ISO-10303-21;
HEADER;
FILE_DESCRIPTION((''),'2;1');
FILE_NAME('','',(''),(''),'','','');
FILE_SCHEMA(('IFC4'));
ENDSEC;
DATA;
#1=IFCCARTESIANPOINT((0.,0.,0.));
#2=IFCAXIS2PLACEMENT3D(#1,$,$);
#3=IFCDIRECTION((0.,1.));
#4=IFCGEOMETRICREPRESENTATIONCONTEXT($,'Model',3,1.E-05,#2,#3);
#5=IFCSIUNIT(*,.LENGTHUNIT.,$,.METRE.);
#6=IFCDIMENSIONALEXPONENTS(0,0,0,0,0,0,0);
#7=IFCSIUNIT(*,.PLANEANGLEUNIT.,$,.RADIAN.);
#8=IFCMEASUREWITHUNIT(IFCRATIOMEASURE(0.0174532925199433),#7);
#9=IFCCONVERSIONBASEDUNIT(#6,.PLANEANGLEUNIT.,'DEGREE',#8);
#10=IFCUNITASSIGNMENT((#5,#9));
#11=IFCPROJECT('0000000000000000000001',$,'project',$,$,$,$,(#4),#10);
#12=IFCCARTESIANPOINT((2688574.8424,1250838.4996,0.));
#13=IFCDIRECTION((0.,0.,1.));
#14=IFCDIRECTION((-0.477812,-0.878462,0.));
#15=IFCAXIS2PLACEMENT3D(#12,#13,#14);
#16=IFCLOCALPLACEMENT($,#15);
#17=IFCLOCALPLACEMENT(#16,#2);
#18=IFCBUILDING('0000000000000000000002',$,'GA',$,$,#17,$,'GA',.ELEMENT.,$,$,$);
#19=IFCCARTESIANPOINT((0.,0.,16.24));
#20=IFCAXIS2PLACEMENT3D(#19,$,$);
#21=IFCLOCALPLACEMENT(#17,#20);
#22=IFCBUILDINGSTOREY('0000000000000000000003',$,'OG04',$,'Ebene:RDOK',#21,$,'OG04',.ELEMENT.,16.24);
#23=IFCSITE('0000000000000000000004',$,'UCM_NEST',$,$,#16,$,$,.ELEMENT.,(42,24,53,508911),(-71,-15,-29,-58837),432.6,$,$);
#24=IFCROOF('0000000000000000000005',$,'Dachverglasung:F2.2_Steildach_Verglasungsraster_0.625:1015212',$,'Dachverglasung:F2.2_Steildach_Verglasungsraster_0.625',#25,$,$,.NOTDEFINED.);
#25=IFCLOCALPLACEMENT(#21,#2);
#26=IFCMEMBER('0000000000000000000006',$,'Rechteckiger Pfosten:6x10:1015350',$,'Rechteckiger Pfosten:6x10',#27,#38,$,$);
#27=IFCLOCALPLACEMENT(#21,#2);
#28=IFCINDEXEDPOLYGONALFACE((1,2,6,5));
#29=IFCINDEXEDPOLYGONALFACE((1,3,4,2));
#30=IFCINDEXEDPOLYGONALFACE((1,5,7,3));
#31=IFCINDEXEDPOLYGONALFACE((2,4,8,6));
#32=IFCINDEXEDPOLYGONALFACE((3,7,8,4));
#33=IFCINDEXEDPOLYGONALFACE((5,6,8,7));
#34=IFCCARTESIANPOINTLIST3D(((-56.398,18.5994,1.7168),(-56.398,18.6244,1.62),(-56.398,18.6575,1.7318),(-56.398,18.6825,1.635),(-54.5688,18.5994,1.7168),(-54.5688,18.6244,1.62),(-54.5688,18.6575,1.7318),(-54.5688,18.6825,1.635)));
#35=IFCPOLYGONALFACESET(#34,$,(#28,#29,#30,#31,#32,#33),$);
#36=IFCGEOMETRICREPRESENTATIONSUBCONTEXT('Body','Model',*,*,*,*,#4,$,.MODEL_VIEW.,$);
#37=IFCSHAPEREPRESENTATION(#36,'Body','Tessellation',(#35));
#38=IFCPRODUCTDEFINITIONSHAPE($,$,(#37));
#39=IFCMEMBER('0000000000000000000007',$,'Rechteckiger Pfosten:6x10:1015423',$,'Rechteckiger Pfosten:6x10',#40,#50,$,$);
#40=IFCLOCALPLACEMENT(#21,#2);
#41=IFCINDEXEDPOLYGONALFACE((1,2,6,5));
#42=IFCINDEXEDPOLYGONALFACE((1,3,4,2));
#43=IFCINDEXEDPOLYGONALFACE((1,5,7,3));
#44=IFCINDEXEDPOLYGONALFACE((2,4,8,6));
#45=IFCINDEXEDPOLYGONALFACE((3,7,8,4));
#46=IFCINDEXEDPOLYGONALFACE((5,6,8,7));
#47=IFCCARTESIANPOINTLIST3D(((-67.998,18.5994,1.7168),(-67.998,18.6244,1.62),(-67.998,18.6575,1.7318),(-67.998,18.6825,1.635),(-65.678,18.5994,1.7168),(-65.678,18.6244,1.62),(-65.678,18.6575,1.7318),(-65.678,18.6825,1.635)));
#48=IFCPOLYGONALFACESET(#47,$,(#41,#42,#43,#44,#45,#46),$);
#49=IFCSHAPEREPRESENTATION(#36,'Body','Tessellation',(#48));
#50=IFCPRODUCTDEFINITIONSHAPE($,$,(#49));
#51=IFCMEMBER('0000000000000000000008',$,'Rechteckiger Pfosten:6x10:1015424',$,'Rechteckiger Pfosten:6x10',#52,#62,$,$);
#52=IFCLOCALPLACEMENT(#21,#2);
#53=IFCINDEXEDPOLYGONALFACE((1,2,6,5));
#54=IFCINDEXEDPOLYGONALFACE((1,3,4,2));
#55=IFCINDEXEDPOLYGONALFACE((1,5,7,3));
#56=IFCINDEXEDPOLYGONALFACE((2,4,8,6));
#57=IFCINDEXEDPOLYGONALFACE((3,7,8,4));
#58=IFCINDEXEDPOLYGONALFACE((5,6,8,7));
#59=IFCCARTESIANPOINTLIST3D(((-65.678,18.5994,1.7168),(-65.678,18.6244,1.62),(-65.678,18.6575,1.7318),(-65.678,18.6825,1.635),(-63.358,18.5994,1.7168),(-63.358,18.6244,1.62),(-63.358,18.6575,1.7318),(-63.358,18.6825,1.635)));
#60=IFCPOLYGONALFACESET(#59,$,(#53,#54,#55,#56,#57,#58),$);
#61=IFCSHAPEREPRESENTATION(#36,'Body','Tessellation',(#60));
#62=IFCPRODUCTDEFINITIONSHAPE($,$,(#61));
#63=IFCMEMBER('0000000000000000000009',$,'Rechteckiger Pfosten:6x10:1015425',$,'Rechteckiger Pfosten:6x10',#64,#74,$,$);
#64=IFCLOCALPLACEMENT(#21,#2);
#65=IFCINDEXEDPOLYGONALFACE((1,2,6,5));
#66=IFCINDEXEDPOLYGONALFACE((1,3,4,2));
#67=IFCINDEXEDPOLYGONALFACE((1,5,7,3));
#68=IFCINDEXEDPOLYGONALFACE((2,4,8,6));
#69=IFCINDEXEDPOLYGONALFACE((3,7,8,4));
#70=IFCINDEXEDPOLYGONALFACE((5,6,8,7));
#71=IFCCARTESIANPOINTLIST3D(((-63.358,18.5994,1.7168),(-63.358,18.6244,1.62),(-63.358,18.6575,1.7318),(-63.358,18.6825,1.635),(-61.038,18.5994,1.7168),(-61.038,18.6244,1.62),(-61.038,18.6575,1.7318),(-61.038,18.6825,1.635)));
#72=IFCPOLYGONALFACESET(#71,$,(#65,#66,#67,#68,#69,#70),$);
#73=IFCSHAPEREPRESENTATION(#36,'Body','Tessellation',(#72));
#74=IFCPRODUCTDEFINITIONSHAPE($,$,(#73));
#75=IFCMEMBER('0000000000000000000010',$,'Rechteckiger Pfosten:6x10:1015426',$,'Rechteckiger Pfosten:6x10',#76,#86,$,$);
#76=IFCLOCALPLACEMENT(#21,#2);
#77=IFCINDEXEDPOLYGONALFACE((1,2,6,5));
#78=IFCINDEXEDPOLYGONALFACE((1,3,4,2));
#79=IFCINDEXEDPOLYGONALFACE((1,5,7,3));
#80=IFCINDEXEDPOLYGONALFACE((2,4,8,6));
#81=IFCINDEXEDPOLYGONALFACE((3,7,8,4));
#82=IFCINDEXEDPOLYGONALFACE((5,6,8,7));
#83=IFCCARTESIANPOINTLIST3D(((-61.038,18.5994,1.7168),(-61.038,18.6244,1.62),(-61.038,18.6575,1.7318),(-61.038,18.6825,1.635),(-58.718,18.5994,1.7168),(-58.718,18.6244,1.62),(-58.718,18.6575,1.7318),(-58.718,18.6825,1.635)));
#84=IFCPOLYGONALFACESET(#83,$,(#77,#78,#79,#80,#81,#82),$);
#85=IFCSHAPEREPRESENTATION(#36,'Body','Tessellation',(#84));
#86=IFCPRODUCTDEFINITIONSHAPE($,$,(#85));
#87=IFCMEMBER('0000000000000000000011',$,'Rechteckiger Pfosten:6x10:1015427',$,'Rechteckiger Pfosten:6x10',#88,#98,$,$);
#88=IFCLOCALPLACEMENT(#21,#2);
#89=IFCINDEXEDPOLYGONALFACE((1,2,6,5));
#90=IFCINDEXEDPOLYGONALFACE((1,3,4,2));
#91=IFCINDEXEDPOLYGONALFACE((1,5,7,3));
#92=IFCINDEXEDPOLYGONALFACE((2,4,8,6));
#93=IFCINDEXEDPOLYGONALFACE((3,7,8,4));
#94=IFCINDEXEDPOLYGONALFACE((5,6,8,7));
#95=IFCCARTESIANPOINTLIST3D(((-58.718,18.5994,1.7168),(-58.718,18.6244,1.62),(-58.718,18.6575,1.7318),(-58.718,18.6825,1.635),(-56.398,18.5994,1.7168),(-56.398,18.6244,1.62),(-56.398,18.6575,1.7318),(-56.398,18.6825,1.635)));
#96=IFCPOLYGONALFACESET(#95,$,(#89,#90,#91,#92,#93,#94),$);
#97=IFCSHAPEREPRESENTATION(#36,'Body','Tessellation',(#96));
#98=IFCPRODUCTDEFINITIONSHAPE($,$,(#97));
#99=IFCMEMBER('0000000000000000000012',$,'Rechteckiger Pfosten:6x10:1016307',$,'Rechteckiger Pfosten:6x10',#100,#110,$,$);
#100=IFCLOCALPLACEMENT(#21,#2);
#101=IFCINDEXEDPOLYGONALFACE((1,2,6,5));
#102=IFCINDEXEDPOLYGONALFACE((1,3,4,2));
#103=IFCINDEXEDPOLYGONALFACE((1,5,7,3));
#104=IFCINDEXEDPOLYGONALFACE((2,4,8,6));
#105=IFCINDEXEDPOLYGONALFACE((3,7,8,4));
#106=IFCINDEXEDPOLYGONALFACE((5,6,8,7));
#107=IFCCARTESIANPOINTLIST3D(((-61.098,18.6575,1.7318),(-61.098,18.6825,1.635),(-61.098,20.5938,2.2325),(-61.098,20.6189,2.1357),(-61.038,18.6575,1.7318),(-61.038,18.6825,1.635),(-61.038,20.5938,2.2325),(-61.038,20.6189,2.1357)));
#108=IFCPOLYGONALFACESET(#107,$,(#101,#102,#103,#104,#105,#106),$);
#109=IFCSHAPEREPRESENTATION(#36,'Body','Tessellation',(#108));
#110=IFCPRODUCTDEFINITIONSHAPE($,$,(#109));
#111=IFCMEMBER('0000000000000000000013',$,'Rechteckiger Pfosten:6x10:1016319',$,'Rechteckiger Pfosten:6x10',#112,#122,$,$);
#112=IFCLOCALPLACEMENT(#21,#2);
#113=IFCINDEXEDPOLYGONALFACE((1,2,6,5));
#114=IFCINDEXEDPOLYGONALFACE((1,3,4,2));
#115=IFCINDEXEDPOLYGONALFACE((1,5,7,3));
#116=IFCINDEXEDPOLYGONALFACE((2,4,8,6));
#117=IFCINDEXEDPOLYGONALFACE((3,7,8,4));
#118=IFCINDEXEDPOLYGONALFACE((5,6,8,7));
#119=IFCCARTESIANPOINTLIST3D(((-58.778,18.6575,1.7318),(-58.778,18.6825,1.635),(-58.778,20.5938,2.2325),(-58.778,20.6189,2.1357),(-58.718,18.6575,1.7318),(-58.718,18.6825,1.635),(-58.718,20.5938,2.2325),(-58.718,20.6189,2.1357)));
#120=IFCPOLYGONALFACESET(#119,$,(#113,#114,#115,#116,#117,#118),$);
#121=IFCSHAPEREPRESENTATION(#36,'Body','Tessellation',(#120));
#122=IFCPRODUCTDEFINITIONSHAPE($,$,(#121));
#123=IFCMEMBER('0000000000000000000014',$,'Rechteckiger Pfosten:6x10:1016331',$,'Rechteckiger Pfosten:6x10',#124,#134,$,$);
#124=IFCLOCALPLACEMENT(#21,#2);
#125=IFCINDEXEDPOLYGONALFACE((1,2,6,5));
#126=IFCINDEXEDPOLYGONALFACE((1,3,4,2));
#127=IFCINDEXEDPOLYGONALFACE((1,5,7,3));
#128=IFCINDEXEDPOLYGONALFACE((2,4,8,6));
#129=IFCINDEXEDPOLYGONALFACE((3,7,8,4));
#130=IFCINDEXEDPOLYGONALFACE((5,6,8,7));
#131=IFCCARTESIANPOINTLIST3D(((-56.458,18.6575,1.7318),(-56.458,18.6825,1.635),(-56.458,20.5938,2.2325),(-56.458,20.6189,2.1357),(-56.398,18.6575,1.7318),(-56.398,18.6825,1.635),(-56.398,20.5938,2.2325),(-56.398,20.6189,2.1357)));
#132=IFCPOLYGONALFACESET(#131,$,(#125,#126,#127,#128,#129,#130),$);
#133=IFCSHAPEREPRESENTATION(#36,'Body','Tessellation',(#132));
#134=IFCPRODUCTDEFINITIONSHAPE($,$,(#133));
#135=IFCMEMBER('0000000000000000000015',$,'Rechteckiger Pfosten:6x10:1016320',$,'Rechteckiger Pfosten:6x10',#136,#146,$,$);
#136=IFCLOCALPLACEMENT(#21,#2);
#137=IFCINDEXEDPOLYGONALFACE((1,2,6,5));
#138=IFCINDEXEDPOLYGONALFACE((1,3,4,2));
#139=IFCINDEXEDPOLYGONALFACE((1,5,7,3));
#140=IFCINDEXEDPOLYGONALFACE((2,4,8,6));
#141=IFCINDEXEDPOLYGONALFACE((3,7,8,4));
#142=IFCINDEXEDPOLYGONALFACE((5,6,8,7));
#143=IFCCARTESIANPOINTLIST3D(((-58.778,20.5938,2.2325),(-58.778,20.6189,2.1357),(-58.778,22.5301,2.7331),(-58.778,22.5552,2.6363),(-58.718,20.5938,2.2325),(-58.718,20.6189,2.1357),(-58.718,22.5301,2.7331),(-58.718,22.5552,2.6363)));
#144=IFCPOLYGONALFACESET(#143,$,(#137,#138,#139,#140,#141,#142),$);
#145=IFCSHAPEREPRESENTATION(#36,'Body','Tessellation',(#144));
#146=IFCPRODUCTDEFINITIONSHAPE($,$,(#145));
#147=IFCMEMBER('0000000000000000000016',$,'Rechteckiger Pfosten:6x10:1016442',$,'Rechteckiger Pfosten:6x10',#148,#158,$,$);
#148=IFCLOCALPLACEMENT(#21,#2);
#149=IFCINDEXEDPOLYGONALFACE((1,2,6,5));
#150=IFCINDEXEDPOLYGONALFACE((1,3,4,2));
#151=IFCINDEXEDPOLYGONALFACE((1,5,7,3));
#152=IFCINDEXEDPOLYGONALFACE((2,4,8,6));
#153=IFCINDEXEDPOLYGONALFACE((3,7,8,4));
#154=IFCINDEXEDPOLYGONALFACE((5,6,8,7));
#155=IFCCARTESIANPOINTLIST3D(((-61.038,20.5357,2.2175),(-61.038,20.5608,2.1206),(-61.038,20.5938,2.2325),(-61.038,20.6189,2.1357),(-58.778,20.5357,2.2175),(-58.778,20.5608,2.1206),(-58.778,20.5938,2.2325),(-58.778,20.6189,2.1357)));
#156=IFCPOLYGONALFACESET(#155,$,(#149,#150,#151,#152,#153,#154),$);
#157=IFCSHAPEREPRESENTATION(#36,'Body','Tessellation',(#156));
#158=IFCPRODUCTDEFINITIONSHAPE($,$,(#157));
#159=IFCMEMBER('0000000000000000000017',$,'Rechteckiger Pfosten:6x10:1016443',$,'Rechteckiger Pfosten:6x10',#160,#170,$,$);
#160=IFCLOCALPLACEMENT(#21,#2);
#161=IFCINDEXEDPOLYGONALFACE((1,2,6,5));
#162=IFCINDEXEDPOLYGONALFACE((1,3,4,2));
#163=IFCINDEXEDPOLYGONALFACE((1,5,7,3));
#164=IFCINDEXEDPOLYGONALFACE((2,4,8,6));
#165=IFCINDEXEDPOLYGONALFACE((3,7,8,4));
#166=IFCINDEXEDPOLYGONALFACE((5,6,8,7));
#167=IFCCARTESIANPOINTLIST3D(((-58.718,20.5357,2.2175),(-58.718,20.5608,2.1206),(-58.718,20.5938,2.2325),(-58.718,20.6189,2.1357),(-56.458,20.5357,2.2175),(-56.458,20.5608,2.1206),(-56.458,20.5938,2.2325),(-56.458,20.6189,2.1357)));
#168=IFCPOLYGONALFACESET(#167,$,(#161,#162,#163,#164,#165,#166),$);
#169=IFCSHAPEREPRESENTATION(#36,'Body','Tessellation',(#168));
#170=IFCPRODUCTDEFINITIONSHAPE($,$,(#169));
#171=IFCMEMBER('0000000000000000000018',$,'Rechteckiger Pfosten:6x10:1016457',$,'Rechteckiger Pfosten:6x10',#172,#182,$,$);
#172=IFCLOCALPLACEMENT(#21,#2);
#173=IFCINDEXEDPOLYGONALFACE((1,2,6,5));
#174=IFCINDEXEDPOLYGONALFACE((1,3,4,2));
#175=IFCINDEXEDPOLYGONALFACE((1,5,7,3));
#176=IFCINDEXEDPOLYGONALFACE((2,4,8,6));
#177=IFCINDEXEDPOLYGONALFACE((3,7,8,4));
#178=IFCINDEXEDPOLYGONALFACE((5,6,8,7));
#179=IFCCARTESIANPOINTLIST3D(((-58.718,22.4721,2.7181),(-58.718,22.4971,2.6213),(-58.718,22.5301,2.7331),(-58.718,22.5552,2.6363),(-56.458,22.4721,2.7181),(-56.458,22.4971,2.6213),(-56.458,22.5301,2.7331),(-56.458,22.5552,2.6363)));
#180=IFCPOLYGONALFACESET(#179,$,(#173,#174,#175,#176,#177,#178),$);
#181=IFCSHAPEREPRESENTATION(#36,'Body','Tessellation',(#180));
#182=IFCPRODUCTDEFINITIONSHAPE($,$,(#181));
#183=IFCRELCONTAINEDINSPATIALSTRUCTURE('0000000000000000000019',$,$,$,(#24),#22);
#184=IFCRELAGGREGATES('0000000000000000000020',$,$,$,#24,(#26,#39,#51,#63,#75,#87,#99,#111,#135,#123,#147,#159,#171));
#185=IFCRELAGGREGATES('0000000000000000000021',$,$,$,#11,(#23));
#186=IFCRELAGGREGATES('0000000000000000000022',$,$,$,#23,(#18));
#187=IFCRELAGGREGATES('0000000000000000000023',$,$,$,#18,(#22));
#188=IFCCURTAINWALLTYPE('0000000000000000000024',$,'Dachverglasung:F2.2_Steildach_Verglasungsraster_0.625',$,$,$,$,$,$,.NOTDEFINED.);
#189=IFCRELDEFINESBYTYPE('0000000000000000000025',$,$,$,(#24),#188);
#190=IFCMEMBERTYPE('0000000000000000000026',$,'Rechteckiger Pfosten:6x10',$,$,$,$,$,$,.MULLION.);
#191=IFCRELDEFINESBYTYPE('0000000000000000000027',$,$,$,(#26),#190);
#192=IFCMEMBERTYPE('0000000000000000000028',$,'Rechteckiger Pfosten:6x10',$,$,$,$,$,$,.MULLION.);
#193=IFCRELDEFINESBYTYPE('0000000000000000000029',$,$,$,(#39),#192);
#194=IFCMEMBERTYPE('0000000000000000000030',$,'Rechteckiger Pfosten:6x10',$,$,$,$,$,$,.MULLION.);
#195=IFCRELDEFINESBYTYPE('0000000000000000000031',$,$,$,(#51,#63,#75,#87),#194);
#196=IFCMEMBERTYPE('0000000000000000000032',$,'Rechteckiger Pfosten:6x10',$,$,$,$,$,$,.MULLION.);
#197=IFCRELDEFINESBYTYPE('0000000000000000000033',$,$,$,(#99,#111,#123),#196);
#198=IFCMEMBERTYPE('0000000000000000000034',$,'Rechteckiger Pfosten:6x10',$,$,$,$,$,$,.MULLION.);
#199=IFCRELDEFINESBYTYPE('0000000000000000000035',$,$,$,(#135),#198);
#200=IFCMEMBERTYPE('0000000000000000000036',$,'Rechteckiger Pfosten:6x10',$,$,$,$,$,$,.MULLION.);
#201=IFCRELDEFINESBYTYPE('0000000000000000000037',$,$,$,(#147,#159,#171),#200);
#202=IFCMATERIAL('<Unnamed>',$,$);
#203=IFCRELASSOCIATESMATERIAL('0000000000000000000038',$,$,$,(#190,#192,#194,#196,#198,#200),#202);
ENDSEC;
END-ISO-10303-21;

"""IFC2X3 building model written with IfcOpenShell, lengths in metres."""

from ifc_helpers import new_model, entity, si_unit, converted_unit, direction, frame, origin, origin_2d_with_axis, place, context, subcontext, project, spatial, rectangle, extrude, source, transform, mapped, material, type_object, type_shapes, element, aggregate, save


model = new_model("IFC2X3")

# Units and contexts
model_context = context("Model", 3, precision=1e-05, world=origin(), true_north=direction((0.0, 1.0)))
body_context = subcontext(model_context, "Body", "Model", "MODEL_VIEW")
ifc_project = project(units=[si_unit("LENGTHUNIT", "METRE"), converted_unit("PLANEANGLEUNIT", "DEGREE", entity("IfcRatioMeasure", 0.0174532925199433), si_unit("PLANEANGLEUNIT", "RADIAN"), dimensions=[0, 0, 0, 0, 0, 0, 0])], contexts=[model_context])

# Site, building, storey
site_placement = place(None, frame((2688574.8424, 1250838.4996, 0.0), z_axis=(0.0, 0.0, 1.0), x_axis=(-0.477812, -0.878462, 0.0)))
site = spatial("IfcSite", under=ifc_project, at=site_placement, Name="UCM_NEST", CompositionType="ELEMENT", RefLatitude=(42, 24, 53, 508911), RefLongitude=(-71, -15, -29, -58837), RefElevation=432.6)
building_placement = place(site_placement, origin())
building = spatial("IfcBuilding", under=site, at=building_placement, Name="GA", LongName="GA", CompositionType="ELEMENT")
storey_placement = place(building_placement, frame((0.0, 0.0, 16.24)))
storey = spatial("IfcBuildingStorey", under=building, at=storey_placement, Name="OG04", ObjectType="Ebene:RDOK", LongName="OG04", CompositionType="ELEMENT", Elevation=16.24)

# Roof, members
curtain_wall_type = type_object("IfcCurtainWallType", Name="Dachverglasung:F2.2_Steildach_Verglasungsraster_0.625", PredefinedType="NOTDEFINED")
roof_placement = place(storey_placement, frame((0.0, 0.0, -16.24)))
roof = element("IfcRoof", 1, at=roof_placement, inside=storey, type_object=curtain_wall_type, Name="Dachverglasung:F2.2_Steildach_Verglasungsraster_0.625:1015212", ObjectType="Dachverglasung:F2.2_Steildach_Verglasungsraster_0.625", ShapeType="NOTDEFINED")
ifc_material_1 = material(Name="<Unnamed>")
member_type_1 = type_object("IfcMemberType", Name="Rechteckiger Pfosten:6x10", PredefinedType="MULLION", material=ifc_material_1)
shared_shape_1 = source(origin(), body_context, "Body", "SweptSolid", [
    extrude(rectangle(XDim=0.1, YDim=0.06, at=origin_2d_with_axis()), frame((-0.03, -0.05, -1.8292), z_axis=(0.0, 0.0, 1.0), x_axis=(0.0, -1.0, 0.0)), (0.0, 0.0, 1.0), 1.8292),
])
type_shapes(member_type_1, [shared_shape_1])
member_1_placement = place(roof_placement, frame((-54.5688, 18.6244, 17.86), z_axis=(1.0, 0.0, 0.0), x_axis=(0.0, -0.968163, -0.250322)))
member_1 = element("IfcMember", 2, at=member_1_placement, type_object=member_type_1, Name="Rechteckiger Pfosten:6x10:1015350", ObjectType="Rechteckiger Pfosten:6x10", context=body_context, shape_type="MappedRepresentation", body=[
    mapped(shared_shape_1, transform((0.0, 0.0, 0.0), scale=1.0)),
])
member_type_2 = type_object("IfcMemberType", Name="Rechteckiger Pfosten:6x10", PredefinedType="MULLION", material=ifc_material_1)
shared_shape_2 = source(origin(), body_context, "Body", "SweptSolid", [
    extrude(rectangle(XDim=0.1, YDim=0.06, at=origin_2d_with_axis()), frame((-0.03, -0.05, -2.32), z_axis=(0.0, 0.0, 1.0), x_axis=(0.0, -1.0, 0.0)), (0.0, 0.0, 1.0), 2.32),
])
type_shapes(member_type_2, [shared_shape_2])
member_2_placement = place(roof_placement, frame((-65.678, 18.6244, 17.86), z_axis=(1.0, 0.0, 0.0), x_axis=(0.0, -0.968163, -0.250322)))
member_2 = element("IfcMember", 3, at=member_2_placement, type_object=member_type_2, Name="Rechteckiger Pfosten:6x10:1015423", ObjectType="Rechteckiger Pfosten:6x10", context=body_context, shape_type="MappedRepresentation", body=[
    mapped(shared_shape_2, transform((0.0, 0.0, 0.0), scale=1.0)),
])
member_type_3 = type_object("IfcMemberType", Name="Rechteckiger Pfosten:6x10", PredefinedType="MULLION", material=ifc_material_1)
shared_shape_3 = source(origin(), body_context, "Body", "SweptSolid", [
    extrude(rectangle(XDim=0.1, YDim=0.06, at=origin_2d_with_axis()), frame((-0.03, -0.05, -2.32), z_axis=(0.0, 0.0, 1.0), x_axis=(0.0, -1.0, 0.0)), (0.0, 0.0, 1.0), 2.32),
])
type_shapes(member_type_3, [shared_shape_3])
member_3_placement = place(roof_placement, frame((-63.358, 18.6244, 17.86), z_axis=(1.0, 0.0, 0.0), x_axis=(0.0, -0.968163, -0.250322)))
member_3 = element("IfcMember", 4, at=member_3_placement, type_object=member_type_3, Name="Rechteckiger Pfosten:6x10:1015424", ObjectType="Rechteckiger Pfosten:6x10", context=body_context, shape_type="MappedRepresentation", body=[
    mapped(shared_shape_3, transform((0.0, 0.0, 0.0), scale=1.0)),
])
member_4_placement = place(roof_placement, frame((-61.038, 18.6244, 17.86), z_axis=(1.0, 0.0, 0.0), x_axis=(0.0, -0.968163, -0.250322)))
member_4 = element("IfcMember", 5, at=member_4_placement, type_object=member_type_3, Name="Rechteckiger Pfosten:6x10:1015425", ObjectType="Rechteckiger Pfosten:6x10", context=body_context, shape_type="MappedRepresentation", body=[
    mapped(shared_shape_3, transform((0.0, 0.0, 0.0), scale=1.0)),
])
member_5_placement = place(roof_placement, frame((-58.718, 18.6244, 17.86), z_axis=(1.0, 0.0, 0.0), x_axis=(0.0, -0.968163, -0.250322)))
member_5 = element("IfcMember", 6, at=member_5_placement, type_object=member_type_3, Name="Rechteckiger Pfosten:6x10:1015426", ObjectType="Rechteckiger Pfosten:6x10", context=body_context, shape_type="MappedRepresentation", body=[
    mapped(shared_shape_3, transform((0.0, 0.0, 0.0), scale=1.0)),
])
member_6_placement = place(roof_placement, frame((-56.398, 18.6244, 17.86), z_axis=(1.0, 0.0, 0.0), x_axis=(0.0, -0.968163, -0.250322)))
member_6 = element("IfcMember", 7, at=member_6_placement, type_object=member_type_3, Name="Rechteckiger Pfosten:6x10:1015427", ObjectType="Rechteckiger Pfosten:6x10", context=body_context, shape_type="MappedRepresentation", body=[
    mapped(shared_shape_3, transform((0.0, 0.0, 0.0), scale=1.0)),
])
member_type_4 = type_object("IfcMemberType", Name="Rechteckiger Pfosten:6x10", PredefinedType="MULLION", material=ifc_material_1)
shared_shape_4 = source(origin(), body_context, "Body", "SweptSolid", [
    extrude(rectangle(XDim=0.1, YDim=0.06, at=origin_2d_with_axis()), frame((-0.03, -0.05, -2.0), z_axis=(0.0, 0.0, 1.0), x_axis=(0.0, -1.0, 0.0)), (0.0, 0.0, 1.0), 2.0),
])
type_shapes(member_type_4, [shared_shape_4])
member_7_placement = place(roof_placement, frame((-61.038, 20.6189, 18.3757), z_axis=(0.0, 0.968163, 0.250322), x_axis=(1.0, 0.0, 0.0)))
member_7 = element("IfcMember", 8, at=member_7_placement, type_object=member_type_4, Name="Rechteckiger Pfosten:6x10:1016307", ObjectType="Rechteckiger Pfosten:6x10", context=body_context, shape_type="MappedRepresentation", body=[
    mapped(shared_shape_4, transform((0.0, 0.0, 0.0), scale=1.0)),
])
member_8_placement = place(roof_placement, frame((-58.718, 20.6189, 18.3757), z_axis=(0.0, 0.968163, 0.250322), x_axis=(1.0, 0.0, 0.0)))
member_8 = element("IfcMember", 9, at=member_8_placement, type_object=member_type_4, Name="Rechteckiger Pfosten:6x10:1016319", ObjectType="Rechteckiger Pfosten:6x10", context=body_context, shape_type="MappedRepresentation", body=[
    mapped(shared_shape_4, transform((0.0, 0.0, 0.0), scale=1.0)),
])
member_9_placement = place(roof_placement, frame((-56.398, 20.6189, 18.3757), z_axis=(0.0, 0.968163, 0.250322), x_axis=(1.0, 0.0, 0.0)))
member_9 = element("IfcMember", 10, at=member_9_placement, type_object=member_type_4, Name="Rechteckiger Pfosten:6x10:1016331", ObjectType="Rechteckiger Pfosten:6x10", context=body_context, shape_type="MappedRepresentation", body=[
    mapped(shared_shape_4, transform((0.0, 0.0, 0.0), scale=1.0)),
])
member_type_5 = type_object("IfcMemberType", Name="Rechteckiger Pfosten:6x10", PredefinedType="MULLION", material=ifc_material_1)
shared_shape_5 = source(origin(), body_context, "Body", "SweptSolid", [
    extrude(rectangle(XDim=0.1, YDim=0.06, at=origin_2d_with_axis()), frame((-0.03, -0.05, -2.0), z_axis=(0.0, 0.0, 1.0), x_axis=(0.0, -1.0, 0.0)), (0.0, 0.0, 1.0), 2.0),
])
type_shapes(member_type_5, [shared_shape_5])
member_10_placement = place(roof_placement, frame((-58.718, 22.5552, 18.8763), z_axis=(0.0, 0.968163, 0.250322), x_axis=(1.0, 0.0, 0.0)))
member_10 = element("IfcMember", 11, at=member_10_placement, type_object=member_type_5, Name="Rechteckiger Pfosten:6x10:1016320", ObjectType="Rechteckiger Pfosten:6x10", context=body_context, shape_type="MappedRepresentation", body=[
    mapped(shared_shape_5, transform((0.0, 0.0, 0.0), scale=1.0)),
])
member_type_6 = type_object("IfcMemberType", Name="Rechteckiger Pfosten:6x10", PredefinedType="MULLION", material=ifc_material_1)
shared_shape_6 = source(origin(), body_context, "Body", "SweptSolid", [
    extrude(rectangle(XDim=0.1, YDim=0.06, at=origin_2d_with_axis()), frame((-0.03, -0.05, -2.26), z_axis=(0.0, 0.0, 1.0), x_axis=(0.0, -1.0, 0.0)), (0.0, 0.0, 1.0), 2.26),
])
type_shapes(member_type_6, [shared_shape_6])
member_11_placement = place(roof_placement, frame((-61.038, 20.6189, 18.3757), z_axis=(-1.0, 0.0, 0.0), x_axis=(0.0, 0.968163, 0.250322)))
member_11 = element("IfcMember", 12, at=member_11_placement, type_object=member_type_6, Name="Rechteckiger Pfosten:6x10:1016442", ObjectType="Rechteckiger Pfosten:6x10", context=body_context, shape_type="MappedRepresentation", body=[
    mapped(shared_shape_6, transform((0.0, 0.0, 0.0), scale=1.0)),
])
member_12_placement = place(roof_placement, frame((-58.718, 20.6189, 18.3757), z_axis=(-1.0, 0.0, 0.0), x_axis=(0.0, 0.968163, 0.250322)))
member_12 = element("IfcMember", 13, at=member_12_placement, type_object=member_type_6, Name="Rechteckiger Pfosten:6x10:1016443", ObjectType="Rechteckiger Pfosten:6x10", context=body_context, shape_type="MappedRepresentation", body=[
    mapped(shared_shape_6, transform((0.0, 0.0, 0.0), scale=1.0)),
])
member_13_placement = place(roof_placement, frame((-58.718, 22.5552, 18.8763), z_axis=(-1.0, 0.0, 0.0), x_axis=(0.0, 0.968163, 0.250322)))
member_13 = element("IfcMember", 14, at=member_13_placement, type_object=member_type_6, Name="Rechteckiger Pfosten:6x10:1016457", ObjectType="Rechteckiger Pfosten:6x10", context=body_context, shape_type="MappedRepresentation", body=[
    mapped(shared_shape_6, transform((0.0, 0.0, 0.0), scale=1.0)),
])
aggregate(roof, [member_1, member_2, member_3, member_4, member_5, member_6, member_7, member_8, member_10, member_9, member_11, member_12, member_13])

save(model, "model.ifc")
